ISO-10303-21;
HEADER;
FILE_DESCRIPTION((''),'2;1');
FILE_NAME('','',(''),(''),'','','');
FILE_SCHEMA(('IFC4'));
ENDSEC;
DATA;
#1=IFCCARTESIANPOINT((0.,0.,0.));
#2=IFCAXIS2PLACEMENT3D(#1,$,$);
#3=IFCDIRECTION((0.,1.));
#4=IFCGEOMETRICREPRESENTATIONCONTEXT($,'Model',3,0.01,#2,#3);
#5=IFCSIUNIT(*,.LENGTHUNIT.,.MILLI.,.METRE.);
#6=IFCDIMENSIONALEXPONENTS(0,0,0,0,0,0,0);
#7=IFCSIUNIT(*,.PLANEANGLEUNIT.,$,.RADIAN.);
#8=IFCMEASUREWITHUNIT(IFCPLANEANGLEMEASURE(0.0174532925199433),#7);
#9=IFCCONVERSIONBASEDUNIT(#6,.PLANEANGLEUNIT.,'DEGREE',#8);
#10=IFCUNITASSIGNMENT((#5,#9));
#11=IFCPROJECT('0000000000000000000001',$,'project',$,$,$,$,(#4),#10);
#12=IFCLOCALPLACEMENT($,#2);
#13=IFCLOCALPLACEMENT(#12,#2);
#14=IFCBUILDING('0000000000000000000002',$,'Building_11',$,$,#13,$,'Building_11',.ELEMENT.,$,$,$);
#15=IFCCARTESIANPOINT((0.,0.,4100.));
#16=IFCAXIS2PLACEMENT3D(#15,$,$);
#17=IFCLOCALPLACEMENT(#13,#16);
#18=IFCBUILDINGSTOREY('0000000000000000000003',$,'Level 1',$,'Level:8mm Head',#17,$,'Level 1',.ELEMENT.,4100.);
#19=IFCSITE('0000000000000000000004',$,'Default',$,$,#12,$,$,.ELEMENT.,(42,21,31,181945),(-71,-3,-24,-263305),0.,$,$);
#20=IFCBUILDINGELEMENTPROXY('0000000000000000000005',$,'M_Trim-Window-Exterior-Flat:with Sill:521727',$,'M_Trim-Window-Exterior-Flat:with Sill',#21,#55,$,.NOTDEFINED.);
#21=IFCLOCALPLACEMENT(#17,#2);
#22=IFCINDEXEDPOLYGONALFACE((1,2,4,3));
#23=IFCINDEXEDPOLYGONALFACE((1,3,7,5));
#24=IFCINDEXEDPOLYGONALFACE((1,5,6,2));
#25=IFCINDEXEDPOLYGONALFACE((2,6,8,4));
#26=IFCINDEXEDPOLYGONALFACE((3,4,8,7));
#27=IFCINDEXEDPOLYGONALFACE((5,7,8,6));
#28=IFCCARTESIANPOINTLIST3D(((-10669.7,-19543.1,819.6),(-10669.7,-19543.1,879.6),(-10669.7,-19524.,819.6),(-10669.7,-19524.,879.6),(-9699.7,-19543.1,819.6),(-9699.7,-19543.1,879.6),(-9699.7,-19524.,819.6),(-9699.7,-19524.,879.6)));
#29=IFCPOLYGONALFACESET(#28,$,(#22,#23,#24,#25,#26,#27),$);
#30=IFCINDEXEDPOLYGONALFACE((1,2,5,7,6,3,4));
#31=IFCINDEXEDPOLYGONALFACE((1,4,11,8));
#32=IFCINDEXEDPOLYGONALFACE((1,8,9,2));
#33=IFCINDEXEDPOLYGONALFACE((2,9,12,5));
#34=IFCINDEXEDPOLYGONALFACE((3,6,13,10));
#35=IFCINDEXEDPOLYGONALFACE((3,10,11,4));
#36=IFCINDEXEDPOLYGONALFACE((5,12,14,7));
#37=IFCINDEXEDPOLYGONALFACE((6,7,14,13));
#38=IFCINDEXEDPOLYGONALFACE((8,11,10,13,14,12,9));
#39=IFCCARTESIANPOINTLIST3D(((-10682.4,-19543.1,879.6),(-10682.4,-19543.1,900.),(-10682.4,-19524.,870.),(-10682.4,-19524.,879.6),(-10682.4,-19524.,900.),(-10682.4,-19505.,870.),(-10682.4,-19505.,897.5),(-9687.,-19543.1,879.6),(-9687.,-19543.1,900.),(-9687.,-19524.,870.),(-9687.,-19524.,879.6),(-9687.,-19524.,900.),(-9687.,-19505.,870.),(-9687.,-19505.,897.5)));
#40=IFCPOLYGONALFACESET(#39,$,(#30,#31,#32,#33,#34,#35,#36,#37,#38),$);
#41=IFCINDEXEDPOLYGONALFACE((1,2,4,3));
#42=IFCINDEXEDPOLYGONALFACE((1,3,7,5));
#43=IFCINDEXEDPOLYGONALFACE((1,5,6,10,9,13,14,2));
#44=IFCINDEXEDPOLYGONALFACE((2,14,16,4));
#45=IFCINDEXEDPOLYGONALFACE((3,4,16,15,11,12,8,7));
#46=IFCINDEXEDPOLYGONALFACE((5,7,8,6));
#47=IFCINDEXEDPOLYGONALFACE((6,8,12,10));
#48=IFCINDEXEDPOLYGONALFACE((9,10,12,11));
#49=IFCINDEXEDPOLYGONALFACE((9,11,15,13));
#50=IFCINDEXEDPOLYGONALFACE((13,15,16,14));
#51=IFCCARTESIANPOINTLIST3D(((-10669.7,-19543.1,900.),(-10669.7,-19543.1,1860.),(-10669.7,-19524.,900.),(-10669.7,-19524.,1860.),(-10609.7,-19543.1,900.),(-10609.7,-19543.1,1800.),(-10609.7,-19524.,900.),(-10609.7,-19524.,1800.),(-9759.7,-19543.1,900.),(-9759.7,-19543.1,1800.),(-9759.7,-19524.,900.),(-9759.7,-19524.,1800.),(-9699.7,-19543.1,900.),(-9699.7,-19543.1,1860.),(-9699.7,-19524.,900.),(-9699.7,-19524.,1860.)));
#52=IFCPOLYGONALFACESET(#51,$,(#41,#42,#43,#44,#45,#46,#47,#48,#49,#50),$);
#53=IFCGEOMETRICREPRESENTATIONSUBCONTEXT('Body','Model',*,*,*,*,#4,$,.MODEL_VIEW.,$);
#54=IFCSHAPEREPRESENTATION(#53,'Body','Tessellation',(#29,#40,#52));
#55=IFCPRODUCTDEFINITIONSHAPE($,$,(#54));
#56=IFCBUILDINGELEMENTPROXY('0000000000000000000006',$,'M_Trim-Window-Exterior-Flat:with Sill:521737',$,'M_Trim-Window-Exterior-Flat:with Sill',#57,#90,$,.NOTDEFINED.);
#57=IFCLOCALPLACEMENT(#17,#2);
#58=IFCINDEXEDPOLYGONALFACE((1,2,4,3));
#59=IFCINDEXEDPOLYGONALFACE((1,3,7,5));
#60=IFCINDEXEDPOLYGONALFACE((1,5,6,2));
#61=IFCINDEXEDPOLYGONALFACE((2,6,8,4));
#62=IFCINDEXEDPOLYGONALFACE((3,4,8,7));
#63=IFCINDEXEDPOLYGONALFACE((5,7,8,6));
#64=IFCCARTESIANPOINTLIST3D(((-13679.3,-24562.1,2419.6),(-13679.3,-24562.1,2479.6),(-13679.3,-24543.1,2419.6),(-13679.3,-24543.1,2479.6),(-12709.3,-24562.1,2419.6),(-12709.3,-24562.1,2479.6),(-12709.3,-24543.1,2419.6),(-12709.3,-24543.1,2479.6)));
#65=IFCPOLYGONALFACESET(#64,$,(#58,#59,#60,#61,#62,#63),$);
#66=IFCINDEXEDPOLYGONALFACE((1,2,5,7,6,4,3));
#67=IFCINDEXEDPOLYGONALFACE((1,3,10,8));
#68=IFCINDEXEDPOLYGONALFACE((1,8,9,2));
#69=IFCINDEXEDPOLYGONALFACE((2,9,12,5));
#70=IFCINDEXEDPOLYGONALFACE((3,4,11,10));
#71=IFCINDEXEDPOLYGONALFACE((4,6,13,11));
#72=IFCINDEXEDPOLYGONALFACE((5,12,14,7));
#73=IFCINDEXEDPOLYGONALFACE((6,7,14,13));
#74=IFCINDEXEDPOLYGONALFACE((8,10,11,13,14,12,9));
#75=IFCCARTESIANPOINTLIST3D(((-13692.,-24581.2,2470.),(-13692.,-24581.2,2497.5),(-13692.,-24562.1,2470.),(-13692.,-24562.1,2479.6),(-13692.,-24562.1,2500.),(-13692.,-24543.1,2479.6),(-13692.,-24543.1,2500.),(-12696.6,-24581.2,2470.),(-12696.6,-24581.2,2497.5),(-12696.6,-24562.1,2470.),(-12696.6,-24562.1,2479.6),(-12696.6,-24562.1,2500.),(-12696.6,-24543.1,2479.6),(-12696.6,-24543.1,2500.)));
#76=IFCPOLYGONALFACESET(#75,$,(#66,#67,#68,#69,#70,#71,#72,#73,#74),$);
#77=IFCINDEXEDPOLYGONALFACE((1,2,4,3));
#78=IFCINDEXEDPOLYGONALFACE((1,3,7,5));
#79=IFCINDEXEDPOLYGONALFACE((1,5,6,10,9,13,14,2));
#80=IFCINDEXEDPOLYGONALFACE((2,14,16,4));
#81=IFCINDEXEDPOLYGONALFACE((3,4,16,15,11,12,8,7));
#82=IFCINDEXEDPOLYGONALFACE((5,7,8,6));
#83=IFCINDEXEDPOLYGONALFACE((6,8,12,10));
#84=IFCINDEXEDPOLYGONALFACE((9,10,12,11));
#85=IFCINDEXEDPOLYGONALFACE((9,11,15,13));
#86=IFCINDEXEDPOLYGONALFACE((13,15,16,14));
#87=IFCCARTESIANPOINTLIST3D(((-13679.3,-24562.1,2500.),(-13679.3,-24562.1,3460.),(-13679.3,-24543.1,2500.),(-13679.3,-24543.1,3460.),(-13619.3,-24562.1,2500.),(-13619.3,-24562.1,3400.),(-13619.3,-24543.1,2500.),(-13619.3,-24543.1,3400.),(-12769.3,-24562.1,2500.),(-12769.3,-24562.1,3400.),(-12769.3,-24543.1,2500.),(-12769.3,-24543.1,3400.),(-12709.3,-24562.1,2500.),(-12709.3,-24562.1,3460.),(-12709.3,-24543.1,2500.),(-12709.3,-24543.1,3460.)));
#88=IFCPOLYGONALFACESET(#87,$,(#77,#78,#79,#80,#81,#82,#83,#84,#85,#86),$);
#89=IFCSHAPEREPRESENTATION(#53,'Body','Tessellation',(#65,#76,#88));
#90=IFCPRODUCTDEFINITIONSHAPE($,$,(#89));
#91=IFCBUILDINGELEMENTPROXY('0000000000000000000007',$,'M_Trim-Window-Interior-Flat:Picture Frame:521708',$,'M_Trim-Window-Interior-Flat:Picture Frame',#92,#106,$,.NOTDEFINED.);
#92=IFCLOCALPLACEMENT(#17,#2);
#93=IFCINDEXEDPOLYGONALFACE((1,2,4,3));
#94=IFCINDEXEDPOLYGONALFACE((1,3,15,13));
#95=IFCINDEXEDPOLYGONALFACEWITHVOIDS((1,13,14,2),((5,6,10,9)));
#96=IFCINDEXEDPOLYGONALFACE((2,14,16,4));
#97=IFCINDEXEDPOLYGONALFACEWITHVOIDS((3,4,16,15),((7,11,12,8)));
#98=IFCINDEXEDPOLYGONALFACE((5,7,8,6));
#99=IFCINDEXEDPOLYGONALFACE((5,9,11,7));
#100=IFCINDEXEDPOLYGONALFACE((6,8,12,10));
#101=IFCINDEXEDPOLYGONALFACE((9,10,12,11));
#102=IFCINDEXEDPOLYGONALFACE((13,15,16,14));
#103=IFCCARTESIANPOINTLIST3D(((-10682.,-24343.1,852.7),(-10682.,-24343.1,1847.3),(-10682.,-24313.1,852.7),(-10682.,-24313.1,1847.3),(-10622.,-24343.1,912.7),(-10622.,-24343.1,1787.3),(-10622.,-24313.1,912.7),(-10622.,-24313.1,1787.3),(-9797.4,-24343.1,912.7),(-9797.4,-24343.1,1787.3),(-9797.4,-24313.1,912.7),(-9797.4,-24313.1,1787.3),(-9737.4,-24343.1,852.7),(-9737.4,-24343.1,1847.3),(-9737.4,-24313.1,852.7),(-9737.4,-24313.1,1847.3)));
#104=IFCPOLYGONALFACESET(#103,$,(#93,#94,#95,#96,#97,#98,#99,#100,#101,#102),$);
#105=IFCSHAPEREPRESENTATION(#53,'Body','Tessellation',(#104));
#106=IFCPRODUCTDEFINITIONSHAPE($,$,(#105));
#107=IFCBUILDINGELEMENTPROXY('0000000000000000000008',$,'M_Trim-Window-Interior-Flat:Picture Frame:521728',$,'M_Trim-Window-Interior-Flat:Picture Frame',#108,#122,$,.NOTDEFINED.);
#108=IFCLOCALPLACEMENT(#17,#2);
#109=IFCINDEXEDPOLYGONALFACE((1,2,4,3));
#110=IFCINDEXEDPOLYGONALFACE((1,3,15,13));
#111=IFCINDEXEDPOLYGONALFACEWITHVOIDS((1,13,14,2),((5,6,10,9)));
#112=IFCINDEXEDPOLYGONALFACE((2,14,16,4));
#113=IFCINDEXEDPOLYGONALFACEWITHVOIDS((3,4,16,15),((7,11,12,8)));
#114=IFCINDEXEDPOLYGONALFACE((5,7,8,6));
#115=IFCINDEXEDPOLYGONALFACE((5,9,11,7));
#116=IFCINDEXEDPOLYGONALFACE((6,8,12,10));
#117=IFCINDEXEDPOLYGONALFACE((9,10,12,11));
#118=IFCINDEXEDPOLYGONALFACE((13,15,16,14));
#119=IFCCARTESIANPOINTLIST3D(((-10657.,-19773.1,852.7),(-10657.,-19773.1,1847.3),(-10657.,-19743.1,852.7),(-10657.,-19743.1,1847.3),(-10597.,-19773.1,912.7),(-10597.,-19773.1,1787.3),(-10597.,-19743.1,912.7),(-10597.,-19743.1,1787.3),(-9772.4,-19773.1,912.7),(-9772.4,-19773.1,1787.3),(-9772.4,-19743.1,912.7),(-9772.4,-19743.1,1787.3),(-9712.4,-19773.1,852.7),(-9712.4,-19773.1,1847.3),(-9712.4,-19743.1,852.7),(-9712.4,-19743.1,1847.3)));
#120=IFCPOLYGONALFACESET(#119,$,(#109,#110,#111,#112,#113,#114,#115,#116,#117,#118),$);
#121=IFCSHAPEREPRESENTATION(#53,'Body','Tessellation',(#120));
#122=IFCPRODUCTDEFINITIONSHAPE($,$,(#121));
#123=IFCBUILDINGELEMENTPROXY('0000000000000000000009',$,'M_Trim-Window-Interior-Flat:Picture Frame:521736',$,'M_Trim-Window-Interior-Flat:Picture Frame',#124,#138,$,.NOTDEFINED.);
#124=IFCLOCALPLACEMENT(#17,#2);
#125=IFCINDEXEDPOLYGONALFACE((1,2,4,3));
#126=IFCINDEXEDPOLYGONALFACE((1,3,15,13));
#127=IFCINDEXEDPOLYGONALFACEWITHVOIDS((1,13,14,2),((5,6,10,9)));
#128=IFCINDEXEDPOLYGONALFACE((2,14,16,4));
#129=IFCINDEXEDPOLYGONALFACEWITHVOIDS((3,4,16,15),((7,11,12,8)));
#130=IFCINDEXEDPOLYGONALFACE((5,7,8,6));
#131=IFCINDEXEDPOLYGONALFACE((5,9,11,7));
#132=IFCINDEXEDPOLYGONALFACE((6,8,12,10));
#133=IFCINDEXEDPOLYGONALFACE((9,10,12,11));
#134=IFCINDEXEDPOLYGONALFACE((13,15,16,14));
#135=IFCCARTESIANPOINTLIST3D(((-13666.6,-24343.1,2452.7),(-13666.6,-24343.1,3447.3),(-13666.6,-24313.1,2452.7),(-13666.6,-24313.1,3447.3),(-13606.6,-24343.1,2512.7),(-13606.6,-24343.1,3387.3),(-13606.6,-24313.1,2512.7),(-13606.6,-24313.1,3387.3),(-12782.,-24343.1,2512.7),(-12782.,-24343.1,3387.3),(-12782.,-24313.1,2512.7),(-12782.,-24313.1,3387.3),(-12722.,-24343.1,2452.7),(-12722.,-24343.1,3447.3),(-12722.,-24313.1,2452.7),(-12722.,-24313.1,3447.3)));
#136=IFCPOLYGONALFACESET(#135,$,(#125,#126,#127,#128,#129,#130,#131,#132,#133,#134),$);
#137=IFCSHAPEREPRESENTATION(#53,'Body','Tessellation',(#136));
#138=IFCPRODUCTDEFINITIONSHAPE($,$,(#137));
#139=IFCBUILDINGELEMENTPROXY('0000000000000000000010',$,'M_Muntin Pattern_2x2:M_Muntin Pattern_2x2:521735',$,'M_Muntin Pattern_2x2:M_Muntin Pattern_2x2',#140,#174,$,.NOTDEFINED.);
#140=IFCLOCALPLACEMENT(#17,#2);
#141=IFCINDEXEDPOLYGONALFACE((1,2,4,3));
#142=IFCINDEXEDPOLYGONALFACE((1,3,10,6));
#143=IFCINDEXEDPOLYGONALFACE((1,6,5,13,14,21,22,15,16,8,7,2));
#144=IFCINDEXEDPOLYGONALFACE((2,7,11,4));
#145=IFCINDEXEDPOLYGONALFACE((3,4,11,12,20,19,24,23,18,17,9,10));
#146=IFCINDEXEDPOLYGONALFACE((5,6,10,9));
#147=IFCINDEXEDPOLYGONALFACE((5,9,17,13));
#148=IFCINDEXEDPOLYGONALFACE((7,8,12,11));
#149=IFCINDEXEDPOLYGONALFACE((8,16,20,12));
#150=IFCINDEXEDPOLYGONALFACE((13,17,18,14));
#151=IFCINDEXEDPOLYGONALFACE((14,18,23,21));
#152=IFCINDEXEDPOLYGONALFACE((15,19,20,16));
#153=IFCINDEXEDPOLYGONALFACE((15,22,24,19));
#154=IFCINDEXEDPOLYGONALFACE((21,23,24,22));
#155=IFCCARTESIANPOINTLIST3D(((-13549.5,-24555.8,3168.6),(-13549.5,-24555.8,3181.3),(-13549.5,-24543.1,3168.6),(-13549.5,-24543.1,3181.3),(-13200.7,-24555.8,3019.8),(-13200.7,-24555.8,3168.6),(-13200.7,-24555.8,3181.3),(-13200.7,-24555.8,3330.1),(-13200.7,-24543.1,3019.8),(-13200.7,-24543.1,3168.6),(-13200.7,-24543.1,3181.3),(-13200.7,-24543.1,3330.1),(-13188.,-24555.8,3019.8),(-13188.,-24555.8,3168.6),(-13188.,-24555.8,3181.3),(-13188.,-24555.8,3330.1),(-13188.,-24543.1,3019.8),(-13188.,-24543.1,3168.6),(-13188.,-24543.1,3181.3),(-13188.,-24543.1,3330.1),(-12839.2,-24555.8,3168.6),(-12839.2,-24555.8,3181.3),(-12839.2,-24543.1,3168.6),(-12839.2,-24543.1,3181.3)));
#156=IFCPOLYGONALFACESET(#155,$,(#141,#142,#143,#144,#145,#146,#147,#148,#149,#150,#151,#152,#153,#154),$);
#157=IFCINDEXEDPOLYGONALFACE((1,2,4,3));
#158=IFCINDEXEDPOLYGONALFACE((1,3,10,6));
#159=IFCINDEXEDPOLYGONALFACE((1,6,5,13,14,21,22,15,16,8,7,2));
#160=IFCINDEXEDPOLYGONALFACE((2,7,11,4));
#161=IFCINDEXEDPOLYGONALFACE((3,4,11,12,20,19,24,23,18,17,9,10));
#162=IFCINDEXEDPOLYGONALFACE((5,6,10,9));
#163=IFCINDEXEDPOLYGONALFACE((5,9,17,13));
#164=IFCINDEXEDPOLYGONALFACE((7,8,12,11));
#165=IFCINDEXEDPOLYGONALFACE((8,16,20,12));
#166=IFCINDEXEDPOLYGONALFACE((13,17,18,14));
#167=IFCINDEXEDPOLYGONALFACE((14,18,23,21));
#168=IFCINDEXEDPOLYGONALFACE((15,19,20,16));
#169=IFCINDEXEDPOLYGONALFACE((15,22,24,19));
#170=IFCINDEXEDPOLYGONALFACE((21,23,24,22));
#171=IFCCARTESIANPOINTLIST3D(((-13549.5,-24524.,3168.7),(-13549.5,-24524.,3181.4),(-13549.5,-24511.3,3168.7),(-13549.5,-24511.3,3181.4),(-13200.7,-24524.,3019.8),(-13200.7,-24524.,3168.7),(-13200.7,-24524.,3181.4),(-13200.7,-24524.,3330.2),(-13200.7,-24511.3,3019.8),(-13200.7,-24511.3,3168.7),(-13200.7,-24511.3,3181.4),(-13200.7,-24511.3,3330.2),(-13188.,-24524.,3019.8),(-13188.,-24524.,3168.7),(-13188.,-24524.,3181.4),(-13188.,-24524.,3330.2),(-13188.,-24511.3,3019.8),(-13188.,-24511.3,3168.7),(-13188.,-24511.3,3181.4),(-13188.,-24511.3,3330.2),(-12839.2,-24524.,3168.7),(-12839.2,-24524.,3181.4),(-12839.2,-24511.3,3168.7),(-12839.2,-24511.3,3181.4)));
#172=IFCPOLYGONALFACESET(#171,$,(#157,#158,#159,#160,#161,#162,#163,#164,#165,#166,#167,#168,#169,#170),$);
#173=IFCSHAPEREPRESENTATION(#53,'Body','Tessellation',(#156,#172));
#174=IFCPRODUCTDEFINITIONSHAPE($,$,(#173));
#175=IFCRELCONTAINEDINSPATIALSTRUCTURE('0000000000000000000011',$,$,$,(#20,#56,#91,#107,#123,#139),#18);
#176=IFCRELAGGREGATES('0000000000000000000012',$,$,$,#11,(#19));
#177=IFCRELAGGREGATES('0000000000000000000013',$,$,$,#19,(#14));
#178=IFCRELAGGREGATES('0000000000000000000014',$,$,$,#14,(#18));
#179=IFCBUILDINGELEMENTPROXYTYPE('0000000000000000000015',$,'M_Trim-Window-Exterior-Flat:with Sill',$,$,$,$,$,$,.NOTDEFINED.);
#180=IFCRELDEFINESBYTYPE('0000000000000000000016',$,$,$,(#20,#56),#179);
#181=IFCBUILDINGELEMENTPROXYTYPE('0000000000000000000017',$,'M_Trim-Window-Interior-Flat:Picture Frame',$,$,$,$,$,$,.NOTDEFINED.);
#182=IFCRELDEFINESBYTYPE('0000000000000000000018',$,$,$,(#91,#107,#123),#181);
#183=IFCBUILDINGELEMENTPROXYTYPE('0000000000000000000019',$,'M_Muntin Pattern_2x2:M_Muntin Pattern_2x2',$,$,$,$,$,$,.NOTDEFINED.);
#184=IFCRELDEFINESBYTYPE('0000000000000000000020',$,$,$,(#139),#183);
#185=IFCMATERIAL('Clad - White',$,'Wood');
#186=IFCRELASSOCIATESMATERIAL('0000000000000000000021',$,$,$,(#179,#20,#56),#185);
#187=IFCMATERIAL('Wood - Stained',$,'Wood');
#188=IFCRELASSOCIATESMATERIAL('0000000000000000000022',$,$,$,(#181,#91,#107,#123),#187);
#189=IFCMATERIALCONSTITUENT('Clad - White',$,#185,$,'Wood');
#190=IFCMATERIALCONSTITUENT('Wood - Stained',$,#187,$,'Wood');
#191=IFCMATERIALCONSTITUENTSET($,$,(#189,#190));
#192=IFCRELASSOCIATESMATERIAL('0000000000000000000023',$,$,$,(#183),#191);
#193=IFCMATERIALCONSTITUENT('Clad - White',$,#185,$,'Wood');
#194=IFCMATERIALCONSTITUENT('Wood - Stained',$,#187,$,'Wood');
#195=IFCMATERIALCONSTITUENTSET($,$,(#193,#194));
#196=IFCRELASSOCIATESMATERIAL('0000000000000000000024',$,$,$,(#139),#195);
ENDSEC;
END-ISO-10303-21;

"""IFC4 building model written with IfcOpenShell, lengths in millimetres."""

from ifc_helpers import new_model, entity, si_unit, converted_unit, direction, frame, origin, place, context, subcontext, project, spatial, indexed_curve, outline, extrude, source, transform, mapped, material, constituent, constituent_set, type_object, type_shapes, element, save


model = new_model("IFC4")

# Units and contexts
model_context = context("Model", 3, precision=0.01, world=origin(), true_north=direction((0.0, 1.0)))
body_context = subcontext(model_context, "Body", "Model", "MODEL_VIEW")
ifc_project = project(units=[si_unit("LENGTHUNIT", "METRE", prefix="MILLI"), converted_unit("PLANEANGLEUNIT", "DEGREE", entity("IfcPlaneAngleMeasure", 0.0174532925199433), si_unit("PLANEANGLEUNIT", "RADIAN"), dimensions=[0, 0, 0, 0, 0, 0, 0])], contexts=[model_context])

# Site, building, storey
site_placement = place(None, origin())
site = spatial("IfcSite", under=ifc_project, at=site_placement, Name="Default", CompositionType="ELEMENT", RefLatitude=(42, 21, 31, 181945), RefLongitude=(-71, -3, -24, -263305), RefElevation=0.0)
building_placement = place(site_placement, origin())
building = spatial("IfcBuilding", under=site, at=building_placement, Name="Building_11", LongName="Building_11", CompositionType="ELEMENT")
storey_placement = place(building_placement, frame((0.0, 0.0, 4100.0)))
storey = spatial("IfcBuildingStorey", under=building, at=storey_placement, Name="Level 1", ObjectType="Level:8mm Head", LongName="Level 1", CompositionType="ELEMENT", Elevation=4100.0)

# Building element proxies
ifc_material_1 = material(Name="Clad - White", Category="Wood")
ifc_material_2 = material(Name="Wood - Stained", Category="Wood")
building_element_proxy_type_1 = type_object("IfcBuildingElementProxyType", Name="M_Trim-Window-Exterior-Flat:with Sill", PredefinedType="NOTDEFINED", material=ifc_material_1)
shared_shape_1 = source(origin(), body_context, "Body", "SweptSolid", [
    extrude(outline(indexed_curve([(-485.0, -30.0), (485.0, -30.0), (485.0, 30.0), (-485.0, 30.0), (-485.0, -30.0)], self_intersect=False)), frame((0.0, -950.4, 0.0), z_axis=(0.0, 0.0, 1.0), x_axis=(-1.0, 0.0, 0.0)), (0.0, 0.0, 1.0), 19.1),
    extrude(outline(indexed_curve([(-19.0, -15.2), (0.0, -15.2), (0.0, -5.7), (19.0, -5.7), (19.0, 14.8), (0.0, 14.8), (-19.0, 12.3), (-19.0, -15.2)], self_intersect=False)), frame((-497.7, -914.8, 19.0), z_axis=(1.0, 0.0, 0.0), x_axis=(0.0, 0.0, -1.0)), (0.0, 0.0, 1.0), 995.4),
    extrude(outline(indexed_curve([(-495.0, -485.0), (465.0, -485.0), (465.0, -425.0), (-435.0, -425.0), (-435.0, 425.0), (465.0, 425.0), (465.0, 485.0), (-495.0, 485.0), (-495.0, -485.0)], self_intersect=False)), frame((0.0, -435.0, 0.0), z_axis=(0.0, 0.0, 1.0), x_axis=(0.0, -1.0, 0.0)), (0.0, 0.0, 1.0), 19.1),
])
type_shapes(building_element_proxy_type_1, [shared_shape_1])
for number, where, z_axis, x_axis, name in (
    (1, (-10184.7, -19543.1, 1800.0), (0.0, 1.0, 0.0), (-1.0, 0.0, 0.0), "M_Trim-Window-Exterior-Flat:with Sill:521727"),
    (2, (-13194.3, -24543.1, 3400.0), (0.0, -1.0, 0.0), (1.0, 0.0, 0.0), "M_Trim-Window-Exterior-Flat:with Sill:521737"),
):
    element("IfcBuildingElementProxy", number, at=place(storey_placement, frame(where, z_axis=z_axis, x_axis=x_axis)), inside=storey, type_object=building_element_proxy_type_1, material=ifc_material_1, Name=name, ObjectType="M_Trim-Window-Exterior-Flat:with Sill", PredefinedType="NOTDEFINED", context=body_context, shape_type="MappedRepresentation", body=[
        mapped(shared_shape_1, transform((0.0, 0.0, 0.0), scale=1.0)),
    ])
building_element_proxy_type_2 = type_object("IfcBuildingElementProxyType", Name="M_Trim-Window-Interior-Flat:Picture Frame", PredefinedType="NOTDEFINED", material=ifc_material_2)
shared_shape_2 = source(origin(), body_context, "Body", "SweptSolid", [
    extrude(outline(indexed_curve([(-472.3, -497.3), (472.3, -497.3), (472.3, 497.3), (-472.3, 497.3), (-472.3, -497.3)], self_intersect=False), holes=[indexed_curve([(-412.3, -437.3), (-412.3, 437.3), (412.3, 437.3), (412.3, -437.3), (-412.3, -437.3)], self_intersect=False)]), frame((0.0, -450.0, 0.0), z_axis=(0.0, 0.0, 1.0), x_axis=(-1.0, 0.0, 0.0)), (0.0, 0.0, 1.0), 30.0),
])
type_shapes(building_element_proxy_type_2, [shared_shape_2])
for number, where, z_axis, x_axis, name in (
    (3, (-10209.7, -24343.1, 1800.0), (0.0, 1.0, 0.0), (-1.0, 0.0, 0.0), "M_Trim-Window-Interior-Flat:Picture Frame:521708"),
    (4, (-10184.7, -19743.1, 1800.0), (0.0, -1.0, 0.0), (1.0, 0.0, 0.0), "M_Trim-Window-Interior-Flat:Picture Frame:521728"),
    (5, (-13194.3, -24343.1, 3400.0), (0.0, 1.0, 0.0), (-1.0, 0.0, 0.0), "M_Trim-Window-Interior-Flat:Picture Frame:521736"),
):
    element("IfcBuildingElementProxy", number, at=place(storey_placement, frame(where, z_axis=z_axis, x_axis=x_axis)), inside=storey, type_object=building_element_proxy_type_2, material=ifc_material_2, Name=name, ObjectType="M_Trim-Window-Interior-Flat:Picture Frame", PredefinedType="NOTDEFINED", context=body_context, shape_type="MappedRepresentation", body=[
        mapped(shared_shape_2, transform((0.0, 0.0, 0.0), scale=1.0)),
    ])
ifc_constituent_1 = constituent(ifc_material_1, Name="Clad - White", Category="Wood")
ifc_constituent_2 = constituent(ifc_material_2, Name="Wood - Stained", Category="Wood")
ifc_constituent_set_1 = constituent_set(constituents=[ifc_constituent_1, ifc_constituent_2])
ifc_constituent_3 = constituent(ifc_material_1, Name="Clad - White", Category="Wood")
ifc_constituent_4 = constituent(ifc_material_2, Name="Wood - Stained", Category="Wood")
ifc_constituent_set_2 = constituent_set(constituents=[ifc_constituent_3, ifc_constituent_4])
building_element_proxy_type_3 = type_object("IfcBuildingElementProxyType", Name="M_Muntin Pattern_2x2:M_Muntin Pattern_2x2", PredefinedType="NOTDEFINED", material=ifc_constituent_set_2)
shared_shape_3 = source(origin(), body_context, "Body", "SweptSolid", [
    extrude(outline(indexed_curve([(6.4, -6.4), (155.1, -6.4), (155.1, 6.3), (6.4, 6.3), (6.4, 355.2), (-6.3, 355.2), (-6.3, 6.3), (-155.2, 6.3), (-155.2, -6.4), (-6.3, -6.4), (-6.3, -355.1), (6.4, -355.1), (6.4, -6.4)], self_intersect=False)), frame((0.0, 9.5, 155.1), z_axis=(0.0, 1.0, 0.0), x_axis=(0.0, 0.0, 1.0)), (0.0, 0.0, 1.0), 12.7),
    extrude(outline(indexed_curve([(6.4, -6.4), (155.2, -6.4), (155.2, 6.3), (6.4, 6.3), (6.4, 355.2), (-6.3, 355.2), (-6.3, 6.3), (-155.2, 6.3), (-155.2, -6.4), (-6.3, -6.4), (-6.3, -355.1), (6.4, -355.1), (6.4, -6.4)], self_intersect=False)), frame((0.0, -22.2, 155.2), z_axis=(0.0, 1.0, 0.0), x_axis=(0.0, 0.0, 1.0)), (0.0, 0.0, 1.0), 12.7),
])
type_shapes(building_element_proxy_type_3, [shared_shape_3])
proxy_1_placement = place(storey_placement, frame((-13194.3, -24533.6, 3019.8), z_axis=(0.0, 0.0, 1.0), x_axis=(-1.0, 0.0, 0.0)))
element("IfcBuildingElementProxy", 6, at=proxy_1_placement, inside=storey, type_object=building_element_proxy_type_3, material=ifc_constituent_set_1, Name="M_Muntin Pattern_2x2:M_Muntin Pattern_2x2:521735", ObjectType="M_Muntin Pattern_2x2:M_Muntin Pattern_2x2", PredefinedType="NOTDEFINED", context=body_context, shape_type="MappedRepresentation", body=[
    mapped(shared_shape_3, transform((0.0, 0.0, 0.0), scale=1.0)),
])

save(model, "model.ifc")
